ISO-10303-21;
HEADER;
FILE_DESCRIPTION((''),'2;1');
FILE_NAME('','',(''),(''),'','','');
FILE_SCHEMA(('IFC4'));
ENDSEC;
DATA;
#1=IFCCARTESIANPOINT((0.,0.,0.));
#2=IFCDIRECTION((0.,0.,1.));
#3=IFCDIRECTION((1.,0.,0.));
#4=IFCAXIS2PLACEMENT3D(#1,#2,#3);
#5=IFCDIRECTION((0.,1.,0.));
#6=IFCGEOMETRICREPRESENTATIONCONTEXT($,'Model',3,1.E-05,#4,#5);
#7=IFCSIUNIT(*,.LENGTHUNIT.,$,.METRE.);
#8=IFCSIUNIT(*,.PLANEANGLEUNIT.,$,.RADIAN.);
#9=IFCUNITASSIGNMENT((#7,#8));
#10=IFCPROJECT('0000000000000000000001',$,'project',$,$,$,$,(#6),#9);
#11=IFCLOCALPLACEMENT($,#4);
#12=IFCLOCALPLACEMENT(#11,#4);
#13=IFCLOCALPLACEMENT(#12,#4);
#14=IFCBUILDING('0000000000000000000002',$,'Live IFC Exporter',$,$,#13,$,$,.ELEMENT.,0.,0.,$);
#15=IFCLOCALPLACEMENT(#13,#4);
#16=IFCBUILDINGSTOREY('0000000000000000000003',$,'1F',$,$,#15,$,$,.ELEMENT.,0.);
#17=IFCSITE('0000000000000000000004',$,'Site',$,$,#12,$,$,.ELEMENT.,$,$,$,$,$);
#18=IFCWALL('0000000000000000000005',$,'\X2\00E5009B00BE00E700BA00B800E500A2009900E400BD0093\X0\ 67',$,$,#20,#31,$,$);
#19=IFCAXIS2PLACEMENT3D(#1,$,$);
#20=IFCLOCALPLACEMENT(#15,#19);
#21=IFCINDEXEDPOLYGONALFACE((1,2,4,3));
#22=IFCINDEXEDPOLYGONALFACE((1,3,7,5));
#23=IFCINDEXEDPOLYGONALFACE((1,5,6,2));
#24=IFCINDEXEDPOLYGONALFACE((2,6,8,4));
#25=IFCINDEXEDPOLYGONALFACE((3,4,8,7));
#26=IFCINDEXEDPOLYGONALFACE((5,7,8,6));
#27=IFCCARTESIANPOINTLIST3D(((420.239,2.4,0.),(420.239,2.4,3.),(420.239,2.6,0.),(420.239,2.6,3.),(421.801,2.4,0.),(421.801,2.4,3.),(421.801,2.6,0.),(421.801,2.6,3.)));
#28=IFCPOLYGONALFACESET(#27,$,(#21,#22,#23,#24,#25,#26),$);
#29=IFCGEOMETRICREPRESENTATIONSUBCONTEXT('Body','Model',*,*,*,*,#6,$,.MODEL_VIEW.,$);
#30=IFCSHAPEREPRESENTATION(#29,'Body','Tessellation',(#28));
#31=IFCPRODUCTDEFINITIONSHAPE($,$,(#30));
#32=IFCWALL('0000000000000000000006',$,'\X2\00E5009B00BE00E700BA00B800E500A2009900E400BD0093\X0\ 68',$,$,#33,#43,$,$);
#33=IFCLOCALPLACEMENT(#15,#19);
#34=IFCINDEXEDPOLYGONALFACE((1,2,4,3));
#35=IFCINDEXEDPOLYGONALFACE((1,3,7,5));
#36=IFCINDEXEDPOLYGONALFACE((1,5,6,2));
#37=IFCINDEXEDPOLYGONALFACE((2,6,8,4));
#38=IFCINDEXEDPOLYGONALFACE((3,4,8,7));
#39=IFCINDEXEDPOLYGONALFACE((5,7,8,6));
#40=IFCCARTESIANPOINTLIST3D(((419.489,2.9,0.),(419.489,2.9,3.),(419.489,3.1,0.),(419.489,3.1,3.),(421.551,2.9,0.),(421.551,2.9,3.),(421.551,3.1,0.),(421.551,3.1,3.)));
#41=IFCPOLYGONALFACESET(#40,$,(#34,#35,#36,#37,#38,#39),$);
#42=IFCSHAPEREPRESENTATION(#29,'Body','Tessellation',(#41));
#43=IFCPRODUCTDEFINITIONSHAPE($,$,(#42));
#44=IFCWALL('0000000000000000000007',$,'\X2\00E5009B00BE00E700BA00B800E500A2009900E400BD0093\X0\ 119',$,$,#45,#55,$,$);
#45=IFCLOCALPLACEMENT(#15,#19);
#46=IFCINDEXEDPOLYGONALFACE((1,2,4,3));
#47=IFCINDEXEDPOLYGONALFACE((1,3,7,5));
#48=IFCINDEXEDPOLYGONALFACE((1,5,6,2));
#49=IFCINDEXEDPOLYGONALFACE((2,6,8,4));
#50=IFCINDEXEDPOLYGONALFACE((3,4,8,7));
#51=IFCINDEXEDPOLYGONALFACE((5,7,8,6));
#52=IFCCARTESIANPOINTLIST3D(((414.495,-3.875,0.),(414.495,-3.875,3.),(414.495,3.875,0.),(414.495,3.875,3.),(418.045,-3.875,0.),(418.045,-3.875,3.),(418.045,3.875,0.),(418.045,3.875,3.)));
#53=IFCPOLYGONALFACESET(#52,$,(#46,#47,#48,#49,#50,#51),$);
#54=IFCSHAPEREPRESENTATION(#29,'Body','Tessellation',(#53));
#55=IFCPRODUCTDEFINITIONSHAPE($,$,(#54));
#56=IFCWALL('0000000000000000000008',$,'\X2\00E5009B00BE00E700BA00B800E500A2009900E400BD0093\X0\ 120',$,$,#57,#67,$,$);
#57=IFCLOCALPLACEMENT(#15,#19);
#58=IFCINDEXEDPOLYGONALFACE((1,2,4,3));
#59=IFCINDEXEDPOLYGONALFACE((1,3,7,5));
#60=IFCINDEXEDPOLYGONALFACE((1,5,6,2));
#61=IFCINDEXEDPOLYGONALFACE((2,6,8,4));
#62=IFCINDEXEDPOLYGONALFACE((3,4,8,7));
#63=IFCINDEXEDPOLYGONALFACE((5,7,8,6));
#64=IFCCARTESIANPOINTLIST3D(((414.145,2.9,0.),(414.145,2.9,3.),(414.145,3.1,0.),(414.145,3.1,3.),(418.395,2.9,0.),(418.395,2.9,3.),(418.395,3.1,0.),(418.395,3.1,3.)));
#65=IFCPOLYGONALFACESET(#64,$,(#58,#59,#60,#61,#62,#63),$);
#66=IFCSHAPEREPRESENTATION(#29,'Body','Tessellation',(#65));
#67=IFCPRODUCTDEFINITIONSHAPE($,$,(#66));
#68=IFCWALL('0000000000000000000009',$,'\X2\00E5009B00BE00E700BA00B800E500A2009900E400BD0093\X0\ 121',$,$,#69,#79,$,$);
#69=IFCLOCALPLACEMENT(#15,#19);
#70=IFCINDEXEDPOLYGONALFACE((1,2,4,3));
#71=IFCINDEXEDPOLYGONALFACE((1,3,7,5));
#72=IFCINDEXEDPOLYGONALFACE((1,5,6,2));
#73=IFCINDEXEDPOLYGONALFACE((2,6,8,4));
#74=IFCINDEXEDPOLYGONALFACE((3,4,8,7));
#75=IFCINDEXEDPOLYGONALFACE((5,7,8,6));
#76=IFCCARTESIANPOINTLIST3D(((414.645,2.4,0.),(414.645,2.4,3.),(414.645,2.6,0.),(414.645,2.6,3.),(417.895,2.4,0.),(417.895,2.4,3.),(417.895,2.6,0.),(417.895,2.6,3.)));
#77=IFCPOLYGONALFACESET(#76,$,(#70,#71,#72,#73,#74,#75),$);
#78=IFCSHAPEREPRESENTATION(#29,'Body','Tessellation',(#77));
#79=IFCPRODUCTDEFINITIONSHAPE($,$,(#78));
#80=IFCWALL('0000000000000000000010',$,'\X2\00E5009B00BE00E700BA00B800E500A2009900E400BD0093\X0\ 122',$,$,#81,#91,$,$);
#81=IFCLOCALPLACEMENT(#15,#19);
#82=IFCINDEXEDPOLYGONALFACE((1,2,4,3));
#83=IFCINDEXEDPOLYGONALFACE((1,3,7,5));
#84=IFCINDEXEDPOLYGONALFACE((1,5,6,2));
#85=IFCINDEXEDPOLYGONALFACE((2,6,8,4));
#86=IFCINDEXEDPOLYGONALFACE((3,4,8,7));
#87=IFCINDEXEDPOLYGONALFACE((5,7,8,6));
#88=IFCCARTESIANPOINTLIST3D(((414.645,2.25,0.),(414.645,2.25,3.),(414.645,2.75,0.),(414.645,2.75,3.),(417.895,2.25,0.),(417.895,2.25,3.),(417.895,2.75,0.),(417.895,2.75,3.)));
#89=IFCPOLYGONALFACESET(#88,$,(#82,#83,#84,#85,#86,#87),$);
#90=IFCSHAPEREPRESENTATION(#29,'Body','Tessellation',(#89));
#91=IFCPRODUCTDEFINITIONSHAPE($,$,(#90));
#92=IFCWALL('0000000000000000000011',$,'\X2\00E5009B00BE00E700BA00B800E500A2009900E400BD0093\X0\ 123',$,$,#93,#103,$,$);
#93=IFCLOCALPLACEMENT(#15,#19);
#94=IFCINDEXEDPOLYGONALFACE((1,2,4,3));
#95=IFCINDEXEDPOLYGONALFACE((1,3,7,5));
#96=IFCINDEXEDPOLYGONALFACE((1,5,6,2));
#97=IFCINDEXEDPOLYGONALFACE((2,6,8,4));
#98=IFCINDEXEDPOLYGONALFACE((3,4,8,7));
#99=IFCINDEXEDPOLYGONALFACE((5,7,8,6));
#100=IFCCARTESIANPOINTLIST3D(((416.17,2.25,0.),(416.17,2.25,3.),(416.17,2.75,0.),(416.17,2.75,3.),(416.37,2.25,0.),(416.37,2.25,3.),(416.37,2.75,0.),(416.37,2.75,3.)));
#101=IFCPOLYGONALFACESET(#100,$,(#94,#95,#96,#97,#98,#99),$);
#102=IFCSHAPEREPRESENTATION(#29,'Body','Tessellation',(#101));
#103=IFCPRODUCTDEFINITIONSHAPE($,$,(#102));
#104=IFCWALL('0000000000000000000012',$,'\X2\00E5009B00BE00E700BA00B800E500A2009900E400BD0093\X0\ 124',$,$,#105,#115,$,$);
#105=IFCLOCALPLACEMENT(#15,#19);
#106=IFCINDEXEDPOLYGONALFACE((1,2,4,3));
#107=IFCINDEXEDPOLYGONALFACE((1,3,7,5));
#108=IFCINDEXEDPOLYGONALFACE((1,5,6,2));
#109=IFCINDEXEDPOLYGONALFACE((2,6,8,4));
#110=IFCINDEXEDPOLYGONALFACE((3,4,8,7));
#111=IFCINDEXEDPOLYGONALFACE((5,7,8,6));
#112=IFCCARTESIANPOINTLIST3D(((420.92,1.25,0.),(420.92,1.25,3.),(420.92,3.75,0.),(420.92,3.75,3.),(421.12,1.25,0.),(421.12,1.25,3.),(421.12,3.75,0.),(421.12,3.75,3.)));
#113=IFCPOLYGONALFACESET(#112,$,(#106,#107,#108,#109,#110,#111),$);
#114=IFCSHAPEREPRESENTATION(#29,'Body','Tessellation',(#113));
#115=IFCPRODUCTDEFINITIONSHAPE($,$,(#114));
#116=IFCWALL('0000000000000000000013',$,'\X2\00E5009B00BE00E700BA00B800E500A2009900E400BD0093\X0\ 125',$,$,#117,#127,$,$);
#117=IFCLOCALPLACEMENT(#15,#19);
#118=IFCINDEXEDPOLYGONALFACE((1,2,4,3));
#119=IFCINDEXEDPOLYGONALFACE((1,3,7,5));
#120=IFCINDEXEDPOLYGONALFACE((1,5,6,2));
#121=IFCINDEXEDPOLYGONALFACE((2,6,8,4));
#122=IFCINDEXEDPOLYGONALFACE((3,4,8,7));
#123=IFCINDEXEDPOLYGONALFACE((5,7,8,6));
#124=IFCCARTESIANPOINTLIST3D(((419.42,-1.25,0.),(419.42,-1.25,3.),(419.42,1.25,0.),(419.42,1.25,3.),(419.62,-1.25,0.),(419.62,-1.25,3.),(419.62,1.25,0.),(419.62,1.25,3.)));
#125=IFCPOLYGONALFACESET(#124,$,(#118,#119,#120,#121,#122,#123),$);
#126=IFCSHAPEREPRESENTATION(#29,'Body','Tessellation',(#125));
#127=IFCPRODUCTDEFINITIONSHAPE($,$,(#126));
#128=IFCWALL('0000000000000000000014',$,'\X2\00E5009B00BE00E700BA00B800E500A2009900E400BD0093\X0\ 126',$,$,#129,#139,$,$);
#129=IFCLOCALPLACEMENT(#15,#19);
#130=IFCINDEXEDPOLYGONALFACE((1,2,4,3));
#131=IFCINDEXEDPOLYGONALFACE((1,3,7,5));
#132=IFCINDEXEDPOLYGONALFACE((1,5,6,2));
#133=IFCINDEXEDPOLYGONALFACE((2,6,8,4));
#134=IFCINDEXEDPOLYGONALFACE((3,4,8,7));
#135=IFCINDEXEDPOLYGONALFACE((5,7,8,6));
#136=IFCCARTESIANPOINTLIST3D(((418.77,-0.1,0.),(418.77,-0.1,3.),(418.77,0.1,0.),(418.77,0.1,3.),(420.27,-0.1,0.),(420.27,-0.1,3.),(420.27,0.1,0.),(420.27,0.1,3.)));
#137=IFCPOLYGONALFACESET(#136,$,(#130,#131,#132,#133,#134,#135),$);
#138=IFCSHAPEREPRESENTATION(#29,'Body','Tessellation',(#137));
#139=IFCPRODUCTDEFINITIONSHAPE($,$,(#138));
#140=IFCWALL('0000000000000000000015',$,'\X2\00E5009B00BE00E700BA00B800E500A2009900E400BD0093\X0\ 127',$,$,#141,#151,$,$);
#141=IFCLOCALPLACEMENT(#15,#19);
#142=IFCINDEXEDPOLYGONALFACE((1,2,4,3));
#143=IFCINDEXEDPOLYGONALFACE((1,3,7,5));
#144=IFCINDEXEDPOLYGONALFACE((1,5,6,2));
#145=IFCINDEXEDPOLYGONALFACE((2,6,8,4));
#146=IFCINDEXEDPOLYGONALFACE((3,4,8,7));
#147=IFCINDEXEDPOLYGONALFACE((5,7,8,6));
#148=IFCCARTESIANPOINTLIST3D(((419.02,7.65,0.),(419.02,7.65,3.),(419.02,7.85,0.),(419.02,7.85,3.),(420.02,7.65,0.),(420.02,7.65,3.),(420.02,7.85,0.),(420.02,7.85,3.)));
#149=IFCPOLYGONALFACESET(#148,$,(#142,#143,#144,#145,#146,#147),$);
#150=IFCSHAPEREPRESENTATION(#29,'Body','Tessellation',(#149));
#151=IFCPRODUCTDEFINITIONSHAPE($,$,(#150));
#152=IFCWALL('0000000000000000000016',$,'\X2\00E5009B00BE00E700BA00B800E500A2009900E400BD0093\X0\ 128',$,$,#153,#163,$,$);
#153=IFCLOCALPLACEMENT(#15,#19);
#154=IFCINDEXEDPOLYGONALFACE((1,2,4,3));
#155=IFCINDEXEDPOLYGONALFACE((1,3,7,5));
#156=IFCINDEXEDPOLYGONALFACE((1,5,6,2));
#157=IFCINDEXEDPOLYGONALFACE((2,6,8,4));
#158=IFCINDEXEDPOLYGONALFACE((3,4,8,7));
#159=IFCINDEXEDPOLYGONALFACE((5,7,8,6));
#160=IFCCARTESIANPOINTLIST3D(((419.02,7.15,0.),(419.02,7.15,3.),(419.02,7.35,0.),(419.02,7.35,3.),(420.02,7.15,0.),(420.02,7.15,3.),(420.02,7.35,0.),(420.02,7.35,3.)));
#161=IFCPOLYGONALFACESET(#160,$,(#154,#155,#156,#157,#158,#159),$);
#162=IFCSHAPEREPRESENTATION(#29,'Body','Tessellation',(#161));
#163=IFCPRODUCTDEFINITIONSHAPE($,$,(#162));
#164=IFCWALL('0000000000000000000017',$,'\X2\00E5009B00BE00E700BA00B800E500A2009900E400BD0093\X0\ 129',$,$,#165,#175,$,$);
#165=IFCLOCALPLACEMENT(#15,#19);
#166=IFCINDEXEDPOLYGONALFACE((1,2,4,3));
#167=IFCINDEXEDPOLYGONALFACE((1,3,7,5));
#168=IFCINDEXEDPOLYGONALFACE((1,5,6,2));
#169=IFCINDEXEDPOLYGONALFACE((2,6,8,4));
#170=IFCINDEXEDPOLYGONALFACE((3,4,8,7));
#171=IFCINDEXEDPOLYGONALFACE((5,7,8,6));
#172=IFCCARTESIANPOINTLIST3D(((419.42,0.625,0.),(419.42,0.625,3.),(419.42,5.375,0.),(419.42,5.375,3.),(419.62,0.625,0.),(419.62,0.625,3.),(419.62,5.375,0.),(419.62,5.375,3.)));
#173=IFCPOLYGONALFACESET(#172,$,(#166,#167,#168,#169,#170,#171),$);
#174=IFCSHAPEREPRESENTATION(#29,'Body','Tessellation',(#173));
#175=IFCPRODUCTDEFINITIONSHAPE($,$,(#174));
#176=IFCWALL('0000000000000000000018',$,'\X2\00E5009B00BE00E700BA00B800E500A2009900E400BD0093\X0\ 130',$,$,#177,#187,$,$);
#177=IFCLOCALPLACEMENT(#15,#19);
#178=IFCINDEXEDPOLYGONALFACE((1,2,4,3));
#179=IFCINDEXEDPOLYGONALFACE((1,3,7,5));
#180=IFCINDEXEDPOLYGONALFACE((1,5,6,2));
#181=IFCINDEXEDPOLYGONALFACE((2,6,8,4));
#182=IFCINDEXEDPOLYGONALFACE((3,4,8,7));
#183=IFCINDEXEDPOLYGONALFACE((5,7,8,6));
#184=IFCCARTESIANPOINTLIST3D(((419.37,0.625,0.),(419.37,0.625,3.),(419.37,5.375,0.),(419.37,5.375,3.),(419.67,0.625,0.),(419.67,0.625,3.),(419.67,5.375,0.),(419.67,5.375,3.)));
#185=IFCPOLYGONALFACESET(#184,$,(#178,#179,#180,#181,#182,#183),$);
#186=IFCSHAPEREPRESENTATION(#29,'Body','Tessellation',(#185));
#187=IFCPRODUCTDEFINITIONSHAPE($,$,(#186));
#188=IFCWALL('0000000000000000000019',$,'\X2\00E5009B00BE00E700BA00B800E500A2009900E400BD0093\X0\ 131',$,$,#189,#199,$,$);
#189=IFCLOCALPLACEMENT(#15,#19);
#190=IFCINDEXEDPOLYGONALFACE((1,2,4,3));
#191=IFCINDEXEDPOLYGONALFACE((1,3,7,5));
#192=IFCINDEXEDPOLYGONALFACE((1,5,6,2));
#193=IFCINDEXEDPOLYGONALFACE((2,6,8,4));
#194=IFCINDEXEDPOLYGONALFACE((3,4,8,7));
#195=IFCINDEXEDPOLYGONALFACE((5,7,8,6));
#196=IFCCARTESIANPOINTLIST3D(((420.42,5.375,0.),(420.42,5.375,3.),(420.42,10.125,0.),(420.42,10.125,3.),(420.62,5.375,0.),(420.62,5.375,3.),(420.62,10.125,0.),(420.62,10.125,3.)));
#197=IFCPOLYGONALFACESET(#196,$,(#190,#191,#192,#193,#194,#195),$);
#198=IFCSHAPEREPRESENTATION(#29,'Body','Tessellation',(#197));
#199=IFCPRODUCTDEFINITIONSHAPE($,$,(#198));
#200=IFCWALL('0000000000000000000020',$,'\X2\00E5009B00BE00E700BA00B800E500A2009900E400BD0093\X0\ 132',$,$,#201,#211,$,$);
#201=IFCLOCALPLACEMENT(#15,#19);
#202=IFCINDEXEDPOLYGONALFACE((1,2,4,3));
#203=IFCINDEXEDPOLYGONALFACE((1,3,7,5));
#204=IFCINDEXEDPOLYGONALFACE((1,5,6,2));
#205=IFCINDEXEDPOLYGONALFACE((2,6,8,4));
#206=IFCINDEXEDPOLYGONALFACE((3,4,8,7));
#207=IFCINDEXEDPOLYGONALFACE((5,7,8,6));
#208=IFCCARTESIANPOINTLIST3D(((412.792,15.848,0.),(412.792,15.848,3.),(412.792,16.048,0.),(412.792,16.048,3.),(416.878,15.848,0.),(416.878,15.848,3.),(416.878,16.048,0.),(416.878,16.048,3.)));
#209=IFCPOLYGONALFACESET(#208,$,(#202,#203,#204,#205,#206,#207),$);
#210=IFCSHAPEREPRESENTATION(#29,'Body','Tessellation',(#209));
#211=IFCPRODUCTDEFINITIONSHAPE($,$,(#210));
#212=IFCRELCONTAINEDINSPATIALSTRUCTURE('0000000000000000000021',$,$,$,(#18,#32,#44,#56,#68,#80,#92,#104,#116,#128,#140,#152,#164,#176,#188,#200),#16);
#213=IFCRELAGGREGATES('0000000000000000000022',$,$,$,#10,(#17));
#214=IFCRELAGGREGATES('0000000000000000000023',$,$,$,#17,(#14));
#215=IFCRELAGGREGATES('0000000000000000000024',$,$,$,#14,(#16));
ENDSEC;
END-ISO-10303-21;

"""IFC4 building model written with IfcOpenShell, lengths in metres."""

from ifc_helpers import new_model, si_unit, direction, frame, frame_2d, origin_with_axes, place, context, subcontext, project, spatial, rectangle, extrude, element, save


model = new_model("IFC4")

# Units and contexts
model_context = context("Model", 3, precision=1e-05, world=origin_with_axes(), true_north=direction((0.0, 1.0, 0.0)))
body_context = subcontext(model_context, "Body", "Model", "MODEL_VIEW")
ifc_project = project(units=[si_unit("LENGTHUNIT", "METRE"), si_unit("PLANEANGLEUNIT", "RADIAN")], contexts=[model_context])

# Site, building, storey
placement = place(None, origin_with_axes())
site_placement = place(placement, origin_with_axes())
site = spatial("IfcSite", under=ifc_project, at=site_placement, Name="Site", CompositionType="ELEMENT")
building_placement = place(site_placement, origin_with_axes())
building = spatial("IfcBuilding", under=site, at=building_placement, Name="Live IFC Exporter", CompositionType="ELEMENT", ElevationOfRefHeight=0.0, ElevationOfTerrain=0.0)
storey_placement = place(building_placement, origin_with_axes())
storey = spatial("IfcBuildingStorey", under=building, at=storey_placement, Name="1F", CompositionType="ELEMENT", Elevation=0.0)

# Walls
wall_1_placement = place(storey_placement, frame((421.02, 2.5, 0.0), z_axis=(0.0, 0.0, 1.0), x_axis=(1.0, 0.0, 0.0)))
element("IfcWall", 1, at=wall_1_placement, inside=storey, Name="å\u009b¾çº¸å¢\u0099ä½\u0093 67", context=body_context, shape_type="SweptSolid", body=[
    extrude(rectangle(XDim=1.562, YDim=0.2, at=frame_2d((0.0, 0.0), x_axis=(1.0, 0.0, 0.0))), frame((0.0, 0.0, 0.0), z_axis=(0.0, 0.0, 1.0)), (0.0, 0.0, 1.0), 3.0),
])
wall_2_placement = place(storey_placement, frame((420.52, 3.0, 0.0), z_axis=(0.0, 0.0, 1.0), x_axis=(1.0, 0.0, 0.0)))
element("IfcWall", 2, at=wall_2_placement, inside=storey, Name="å\u009b¾çº¸å¢\u0099ä½\u0093 68", context=body_context, shape_type="SweptSolid", body=[
    extrude(rectangle(XDim=2.062, YDim=0.2, at=frame_2d((0.0, 0.0), x_axis=(1.0, 0.0, 0.0))), frame((0.0, 0.0, 0.0), z_axis=(0.0, 0.0, 1.0)), (0.0, 0.0, 1.0), 3.0),
])
wall_3_placement = place(storey_placement, frame((416.27, 0.0, 0.0), z_axis=(0.0, 0.0, 1.0), x_axis=(1.0, 0.0, 0.0)))
element("IfcWall", 3, at=wall_3_placement, inside=storey, Name="å\u009b¾çº¸å¢\u0099ä½\u0093 119", context=body_context, shape_type="SweptSolid", body=[
    extrude(rectangle(XDim=3.55, YDim=7.75, at=frame_2d((0.0, 0.0), x_axis=(1.0, 0.0, 0.0))), frame((0.0, 0.0, 0.0), z_axis=(0.0, 0.0, 1.0)), (0.0, 0.0, 1.0), 3.0),
])
wall_4_placement = place(storey_placement, frame((416.27, 3.0, 0.0), z_axis=(0.0, 0.0, 1.0), x_axis=(1.0, 0.0, 0.0)))
element("IfcWall", 4, at=wall_4_placement, inside=storey, Name="å\u009b¾çº¸å¢\u0099ä½\u0093 120", context=body_context, shape_type="SweptSolid", body=[
    extrude(rectangle(XDim=4.25, YDim=0.2, at=frame_2d((0.0, 0.0), x_axis=(1.0, 0.0, 0.0))), frame((0.0, 0.0, 0.0), z_axis=(0.0, 0.0, 1.0)), (0.0, 0.0, 1.0), 3.0),
])
wall_5_placement = place(storey_placement, frame((416.27, 2.5, 0.0), z_axis=(0.0, 0.0, 1.0), x_axis=(1.0, 0.0, 0.0)))
element("IfcWall", 5, at=wall_5_placement, inside=storey, Name="å\u009b¾çº¸å¢\u0099ä½\u0093 121", context=body_context, shape_type="SweptSolid", body=[
    extrude(rectangle(XDim=3.25, YDim=0.2, at=frame_2d((0.0, 0.0), x_axis=(1.0, 0.0, 0.0))), frame((0.0, 0.0, 0.0), z_axis=(0.0, 0.0, 1.0)), (0.0, 0.0, 1.0), 3.0),
])
wall_6_placement = place(storey_placement, frame((416.27, 2.5, 0.0), z_axis=(0.0, 0.0, 1.0), x_axis=(1.0, 0.0, 0.0)))
element("IfcWall", 6, at=wall_6_placement, inside=storey, Name="å\u009b¾çº¸å¢\u0099ä½\u0093 122", context=body_context, shape_type="SweptSolid", body=[
    extrude(rectangle(XDim=3.25, YDim=0.5, at=frame_2d((0.0, 0.0), x_axis=(1.0, 0.0, 0.0))), frame((0.0, 0.0, 0.0), z_axis=(0.0, 0.0, 1.0)), (0.0, 0.0, 1.0), 3.0),
])
wall_7_placement = place(storey_placement, frame((416.27, 2.5, 0.0), z_axis=(0.0, 0.0, 1.0), x_axis=(0.0, 1.0, 0.0)))
element("IfcWall", 7, at=wall_7_placement, inside=storey, Name="å\u009b¾çº¸å¢\u0099ä½\u0093 123", context=body_context, shape_type="SweptSolid", body=[
    extrude(rectangle(XDim=0.5, YDim=0.2, at=frame_2d((0.0, 0.0), x_axis=(1.0, 0.0, 0.0))), frame((0.0, 0.0, 0.0), z_axis=(0.0, 0.0, 1.0)), (0.0, 0.0, 1.0), 3.0),
])
for number, where, z_axis, x_axis, name in (
    (8, (421.02, 2.5, 0.0), (0.0, 0.0, 1.0), (0.0, -1.0, 0.0), "å\u009b¾çº¸å¢\u0099ä½\u0093 124"),
    (9, (419.52, 0.0, 0.0), (0.0, 0.0, 1.0), (0.0, 1.0, 0.0), "å\u009b¾çº¸å¢\u0099ä½\u0093 125"),
):
    element("IfcWall", number, at=place(storey_placement, frame(where, z_axis=z_axis, x_axis=x_axis)), inside=storey, Name=name, context=body_context, shape_type="SweptSolid", body=[
        extrude(rectangle(XDim=2.5, YDim=0.2, at=frame_2d((0.0, 0.0), x_axis=(1.0, 0.0, 0.0))), frame((0.0, 0.0, 0.0), z_axis=(0.0, 0.0, 1.0)), (0.0, 0.0, 1.0), 3.0),
    ])
wall_8_placement = place(storey_placement, frame((419.52, 0.0, 0.0), z_axis=(0.0, 0.0, 1.0), x_axis=(1.0, 0.0, 0.0)))
element("IfcWall", 10, at=wall_8_placement, inside=storey, Name="å\u009b¾çº¸å¢\u0099ä½\u0093 126", context=body_context, shape_type="SweptSolid", body=[
    extrude(rectangle(XDim=1.5, YDim=0.2, at=frame_2d((0.0, 0.0), x_axis=(1.0, 0.0, 0.0))), frame((0.0, 0.0, 0.0), z_axis=(0.0, 0.0, 1.0)), (0.0, 0.0, 1.0), 3.0),
])
for number, where, z_axis, x_axis, name in (
    (11, (419.52, 7.75, 0.0), (0.0, 0.0, 1.0), (1.0, 0.0, 0.0), "å\u009b¾çº¸å¢\u0099ä½\u0093 127"),
    (12, (419.52, 7.25, 0.0), (0.0, 0.0, 1.0), (1.0, 0.0, 0.0), "å\u009b¾çº¸å¢\u0099ä½\u0093 128"),
):
    element("IfcWall", number, at=place(storey_placement, frame(where, z_axis=z_axis, x_axis=x_axis)), inside=storey, Name=name, context=body_context, shape_type="SweptSolid", body=[
        extrude(rectangle(XDim=1.0, YDim=0.2, at=frame_2d((0.0, 0.0), x_axis=(1.0, 0.0, 0.0))), frame((0.0, 0.0, 0.0), z_axis=(0.0, 0.0, 1.0)), (0.0, 0.0, 1.0), 3.0),
    ])
wall_9_placement = place(storey_placement, frame((419.52, 3.0, 0.0), z_axis=(0.0, 0.0, 1.0), x_axis=(0.0, 1.0, 0.0)))
element("IfcWall", 13, at=wall_9_placement, inside=storey, Name="å\u009b¾çº¸å¢\u0099ä½\u0093 129", context=body_context, shape_type="SweptSolid", body=[
    extrude(rectangle(XDim=4.75, YDim=0.2, at=frame_2d((0.0, 0.0), x_axis=(1.0, 0.0, 0.0))), frame((0.0, 0.0, 0.0), z_axis=(0.0, 0.0, 1.0)), (0.0, 0.0, 1.0), 3.0),
])
wall_10_placement = place(storey_placement, frame((419.52, 3.0, 0.0), z_axis=(0.0, 0.0, 1.0), x_axis=(1.0, 0.0, 0.0)))
element("IfcWall", 14, at=wall_10_placement, inside=storey, Name="å\u009b¾çº¸å¢\u0099ä½\u0093 130", context=body_context, shape_type="SweptSolid", body=[
    extrude(rectangle(XDim=0.3, YDim=4.75, at=frame_2d((0.0, 0.0), x_axis=(1.0, 0.0, 0.0))), frame((0.0, 0.0, 0.0), z_axis=(0.0, 0.0, 1.0)), (0.0, 0.0, 1.0), 3.0),
])
wall_11_placement = place(storey_placement, frame((420.52, 7.75, 0.0), z_axis=(0.0, 0.0, 1.0), x_axis=(0.0, -1.0, 0.0)))
element("IfcWall", 15, at=wall_11_placement, inside=storey, Name="å\u009b¾çº¸å¢\u0099ä½\u0093 131", context=body_context, shape_type="SweptSolid", body=[
    extrude(rectangle(XDim=4.75, YDim=0.2, at=frame_2d((0.0, 0.0), x_axis=(1.0, 0.0, 0.0))), frame((0.0, 0.0, 0.0), z_axis=(0.0, 0.0, 1.0)), (0.0, 0.0, 1.0), 3.0),
])
for number, where, z_axis, x_axis, name in (
    (16, (414.835, 15.948, 0.0), (0.0, 0.0, 1.0), (1.0, 0.0, 0.0), "å\u009b¾çº¸å¢\u0099ä½\u0093 132"),
):
    element("IfcWall", number, at=place(storey_placement, frame(where, z_axis=z_axis, x_axis=x_axis)), inside=storey, Name=name, context=body_context, shape_type="SweptSolid", body=[
        extrude(rectangle(XDim=4.086, YDim=0.2, at=frame_2d((0.0, 0.0), x_axis=(1.0, 0.0, 0.0))), frame((0.0, 0.0, 0.0), z_axis=(0.0, 0.0, 1.0)), (0.0, 0.0, 1.0), 3.0),
    ])

save(model, "model.ifc")
